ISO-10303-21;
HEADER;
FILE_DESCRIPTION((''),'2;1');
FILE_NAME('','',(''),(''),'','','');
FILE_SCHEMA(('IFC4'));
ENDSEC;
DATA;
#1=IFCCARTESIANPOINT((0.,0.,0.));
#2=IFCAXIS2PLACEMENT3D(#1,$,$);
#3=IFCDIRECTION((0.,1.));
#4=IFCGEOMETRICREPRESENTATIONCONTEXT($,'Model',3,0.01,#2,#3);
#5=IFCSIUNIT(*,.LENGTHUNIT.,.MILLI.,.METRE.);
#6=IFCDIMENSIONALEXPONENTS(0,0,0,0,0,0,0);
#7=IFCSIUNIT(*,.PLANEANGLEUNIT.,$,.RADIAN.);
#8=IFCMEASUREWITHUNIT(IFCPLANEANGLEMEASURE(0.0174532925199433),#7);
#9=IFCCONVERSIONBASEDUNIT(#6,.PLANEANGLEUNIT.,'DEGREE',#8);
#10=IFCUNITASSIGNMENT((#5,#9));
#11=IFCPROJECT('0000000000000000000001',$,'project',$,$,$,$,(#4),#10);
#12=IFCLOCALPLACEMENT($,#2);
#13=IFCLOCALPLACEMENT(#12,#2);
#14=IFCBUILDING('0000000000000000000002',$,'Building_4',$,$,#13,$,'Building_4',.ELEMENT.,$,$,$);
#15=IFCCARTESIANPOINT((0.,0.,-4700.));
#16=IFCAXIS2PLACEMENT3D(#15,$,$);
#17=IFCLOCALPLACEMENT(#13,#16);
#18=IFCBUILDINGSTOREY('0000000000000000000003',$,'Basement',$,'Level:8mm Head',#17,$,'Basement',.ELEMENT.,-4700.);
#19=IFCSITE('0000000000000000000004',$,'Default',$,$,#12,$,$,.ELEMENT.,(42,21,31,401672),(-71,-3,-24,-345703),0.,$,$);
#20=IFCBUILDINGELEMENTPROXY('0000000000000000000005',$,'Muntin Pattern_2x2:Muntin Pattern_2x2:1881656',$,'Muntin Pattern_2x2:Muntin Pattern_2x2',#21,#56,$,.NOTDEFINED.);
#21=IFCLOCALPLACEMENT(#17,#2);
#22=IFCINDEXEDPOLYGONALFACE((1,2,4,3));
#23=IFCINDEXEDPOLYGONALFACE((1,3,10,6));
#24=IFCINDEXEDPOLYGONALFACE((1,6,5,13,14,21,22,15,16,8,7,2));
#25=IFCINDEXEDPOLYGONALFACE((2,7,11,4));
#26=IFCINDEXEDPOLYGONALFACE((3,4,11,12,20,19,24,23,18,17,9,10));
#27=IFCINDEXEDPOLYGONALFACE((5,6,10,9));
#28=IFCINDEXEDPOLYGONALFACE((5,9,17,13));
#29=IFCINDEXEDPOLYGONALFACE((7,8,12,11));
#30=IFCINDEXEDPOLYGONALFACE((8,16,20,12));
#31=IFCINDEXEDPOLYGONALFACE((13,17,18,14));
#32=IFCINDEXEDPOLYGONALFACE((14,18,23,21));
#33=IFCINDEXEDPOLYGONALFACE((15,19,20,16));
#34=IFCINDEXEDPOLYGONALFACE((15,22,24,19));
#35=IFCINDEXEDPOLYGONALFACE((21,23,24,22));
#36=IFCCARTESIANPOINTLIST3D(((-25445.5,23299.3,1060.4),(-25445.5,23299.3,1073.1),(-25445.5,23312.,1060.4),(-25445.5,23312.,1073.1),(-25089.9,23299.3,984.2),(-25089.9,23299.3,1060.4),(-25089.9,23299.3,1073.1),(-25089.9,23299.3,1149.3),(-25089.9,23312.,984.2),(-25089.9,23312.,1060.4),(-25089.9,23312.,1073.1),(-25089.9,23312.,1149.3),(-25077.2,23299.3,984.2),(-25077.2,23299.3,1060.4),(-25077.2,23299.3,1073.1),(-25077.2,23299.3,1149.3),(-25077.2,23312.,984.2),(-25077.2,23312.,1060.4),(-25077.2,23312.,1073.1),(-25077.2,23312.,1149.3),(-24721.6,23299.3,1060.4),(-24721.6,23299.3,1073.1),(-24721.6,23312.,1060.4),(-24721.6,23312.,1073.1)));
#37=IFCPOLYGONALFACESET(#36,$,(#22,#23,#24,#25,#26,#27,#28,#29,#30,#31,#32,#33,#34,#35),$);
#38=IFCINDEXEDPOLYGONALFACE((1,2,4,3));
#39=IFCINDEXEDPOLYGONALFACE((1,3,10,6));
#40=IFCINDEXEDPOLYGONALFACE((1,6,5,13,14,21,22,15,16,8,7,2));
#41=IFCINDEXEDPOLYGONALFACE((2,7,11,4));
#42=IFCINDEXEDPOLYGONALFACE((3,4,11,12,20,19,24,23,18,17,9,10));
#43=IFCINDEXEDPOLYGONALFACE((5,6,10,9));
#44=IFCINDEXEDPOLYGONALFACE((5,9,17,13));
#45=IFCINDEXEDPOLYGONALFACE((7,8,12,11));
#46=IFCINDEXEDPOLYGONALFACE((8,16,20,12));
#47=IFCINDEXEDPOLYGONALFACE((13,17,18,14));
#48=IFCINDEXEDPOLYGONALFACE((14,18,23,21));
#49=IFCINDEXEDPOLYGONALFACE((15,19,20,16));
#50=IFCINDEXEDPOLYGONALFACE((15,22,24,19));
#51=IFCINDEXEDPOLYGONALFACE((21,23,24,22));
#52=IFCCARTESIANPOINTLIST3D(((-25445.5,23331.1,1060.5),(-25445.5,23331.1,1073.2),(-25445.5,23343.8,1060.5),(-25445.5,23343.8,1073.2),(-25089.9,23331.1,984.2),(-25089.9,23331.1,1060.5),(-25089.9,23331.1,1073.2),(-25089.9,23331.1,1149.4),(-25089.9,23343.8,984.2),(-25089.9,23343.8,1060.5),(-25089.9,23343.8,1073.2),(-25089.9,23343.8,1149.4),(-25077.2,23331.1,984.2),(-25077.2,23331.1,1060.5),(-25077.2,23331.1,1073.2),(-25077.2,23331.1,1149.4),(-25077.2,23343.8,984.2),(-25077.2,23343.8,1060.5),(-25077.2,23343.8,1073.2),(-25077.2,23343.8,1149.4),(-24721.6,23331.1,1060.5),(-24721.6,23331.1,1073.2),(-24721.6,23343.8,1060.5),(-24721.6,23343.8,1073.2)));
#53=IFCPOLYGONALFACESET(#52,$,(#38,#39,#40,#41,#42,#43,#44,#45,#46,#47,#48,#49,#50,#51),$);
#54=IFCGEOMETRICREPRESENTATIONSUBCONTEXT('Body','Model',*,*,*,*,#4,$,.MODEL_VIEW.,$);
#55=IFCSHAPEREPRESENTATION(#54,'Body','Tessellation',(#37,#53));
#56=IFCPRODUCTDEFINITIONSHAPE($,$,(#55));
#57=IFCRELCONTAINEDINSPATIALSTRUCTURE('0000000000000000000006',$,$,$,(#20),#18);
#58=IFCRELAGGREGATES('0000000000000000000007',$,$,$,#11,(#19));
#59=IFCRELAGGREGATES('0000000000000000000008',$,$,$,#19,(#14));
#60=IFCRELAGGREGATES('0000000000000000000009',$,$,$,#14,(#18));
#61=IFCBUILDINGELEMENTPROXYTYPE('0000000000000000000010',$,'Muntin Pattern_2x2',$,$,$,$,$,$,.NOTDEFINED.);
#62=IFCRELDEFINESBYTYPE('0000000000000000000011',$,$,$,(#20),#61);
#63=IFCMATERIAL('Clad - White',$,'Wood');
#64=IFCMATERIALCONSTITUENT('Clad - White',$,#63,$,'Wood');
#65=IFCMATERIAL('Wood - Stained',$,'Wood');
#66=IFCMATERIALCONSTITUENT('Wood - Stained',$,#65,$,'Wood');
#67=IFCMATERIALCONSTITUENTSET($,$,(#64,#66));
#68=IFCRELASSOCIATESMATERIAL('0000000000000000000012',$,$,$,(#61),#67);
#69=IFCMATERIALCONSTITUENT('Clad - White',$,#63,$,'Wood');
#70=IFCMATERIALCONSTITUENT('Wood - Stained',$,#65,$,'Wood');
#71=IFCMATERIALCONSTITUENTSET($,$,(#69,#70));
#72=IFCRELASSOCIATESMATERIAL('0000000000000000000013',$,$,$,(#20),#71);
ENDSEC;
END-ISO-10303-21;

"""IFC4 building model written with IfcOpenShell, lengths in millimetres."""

from ifc_helpers import new_model, entity, si_unit, converted_unit, direction, frame, origin, place, context, subcontext, project, spatial, indexed_curve, outline, extrude, source, transform, mapped, material, constituent, constituent_set, type_object, type_shapes, element, save


model = new_model("IFC4")

# Units and contexts
model_context = context("Model", 3, precision=0.01, world=origin(), true_north=direction((0.0, 1.0)))
body_context = subcontext(model_context, "Body", "Model", "MODEL_VIEW")
ifc_project = project(units=[si_unit("LENGTHUNIT", "METRE", prefix="MILLI"), converted_unit("PLANEANGLEUNIT", "DEGREE", entity("IfcPlaneAngleMeasure", 0.0174532925199433), si_unit("PLANEANGLEUNIT", "RADIAN"), dimensions=[0, 0, 0, 0, 0, 0, 0])], contexts=[model_context])

# Site, building, storey
site_placement = place(None, origin())
site = spatial("IfcSite", under=ifc_project, at=site_placement, Name="Default", CompositionType="ELEMENT", RefLatitude=(42, 21, 31, 401672), RefLongitude=(-71, -3, -24, -345703), RefElevation=0.0)
building_placement = place(site_placement, origin())
building = spatial("IfcBuilding", under=site, at=building_placement, Name="Building_4", LongName="Building_4", CompositionType="ELEMENT")
storey_placement = place(building_placement, frame((0.0, 0.0, -4700.0)))
storey = spatial("IfcBuildingStorey", under=building, at=storey_placement, Name="Basement", ObjectType="Level:8mm Head", LongName="Basement", CompositionType="ELEMENT", Elevation=-4700.0)

# Shared definitions
ifc_material_1 = material(Name="Clad - White", Category="Wood")
ifc_material_2 = material(Name="Wood - Stained", Category="Wood")

# Building element proxy
ifc_constituent_1 = constituent(ifc_material_1, Name="Clad - White", Category="Wood")
ifc_constituent_2 = constituent(ifc_material_2, Name="Wood - Stained", Category="Wood")
ifc_constituent_set_1 = constituent_set(constituents=[ifc_constituent_1, ifc_constituent_2])
building_element_proxy_type_1 = type_object("IfcBuildingElementProxyType", Name="Muntin Pattern_2x2", PredefinedType="NOTDEFINED", material=ifc_constituent_set_1)
shared_shape_1 = source(origin(), body_context, "Body", "SweptSolid", [
    extrude(outline(indexed_curve([(6.4, -6.4), (82.5, -6.4), (82.5, 6.3), (6.4, 6.3), (6.4, 362.0), (-6.3, 362.0), (-6.3, 6.3), (-82.6, 6.3), (-82.6, -6.4), (-6.3, -6.4), (-6.3, -361.9), (6.4, -361.9), (6.4, -6.4)], self_intersect=False)), frame((0.0, -22.2, 82.5), z_axis=(0.0, 1.0, 0.0), x_axis=(0.0, 0.0, 1.0)), (0.0, 0.0, 1.0), 12.7),
    extrude(outline(indexed_curve([(6.4, -6.4), (82.6, -6.4), (82.6, 6.3), (6.4, 6.3), (6.4, 362.0), (-6.3, 362.0), (-6.3, 6.3), (-82.6, 6.3), (-82.6, -6.4), (-6.3, -6.4), (-6.3, -361.9), (6.4, -361.9), (6.4, -6.4)], self_intersect=False)), frame((0.0, 9.5, 82.6), z_axis=(0.0, 1.0, 0.0), x_axis=(0.0, 0.0, 1.0)), (0.0, 0.0, 1.0), 12.7),
])
type_shapes(building_element_proxy_type_1, [shared_shape_1])
ifc_constituent_3 = constituent(ifc_material_1, Name="Clad - White", Category="Wood")
ifc_constituent_4 = constituent(ifc_material_2, Name="Wood - Stained", Category="Wood")
ifc_constituent_set_2 = constituent_set(constituents=[ifc_constituent_3, ifc_constituent_4])
proxy_1_placement = place(storey_placement, frame((-25083.6, 23321.5, 984.2)))
element("IfcBuildingElementProxy", 1, at=proxy_1_placement, inside=storey, type_object=building_element_proxy_type_1, material=ifc_constituent_set_2, Name="Muntin Pattern_2x2:Muntin Pattern_2x2:1881656", ObjectType="Muntin Pattern_2x2:Muntin Pattern_2x2", PredefinedType="NOTDEFINED", context=body_context, shape_type="MappedRepresentation", body=[
    mapped(shared_shape_1, transform((0.0, 0.0, 0.0), scale=1.0)),
])

save(model, "model.ifc")
